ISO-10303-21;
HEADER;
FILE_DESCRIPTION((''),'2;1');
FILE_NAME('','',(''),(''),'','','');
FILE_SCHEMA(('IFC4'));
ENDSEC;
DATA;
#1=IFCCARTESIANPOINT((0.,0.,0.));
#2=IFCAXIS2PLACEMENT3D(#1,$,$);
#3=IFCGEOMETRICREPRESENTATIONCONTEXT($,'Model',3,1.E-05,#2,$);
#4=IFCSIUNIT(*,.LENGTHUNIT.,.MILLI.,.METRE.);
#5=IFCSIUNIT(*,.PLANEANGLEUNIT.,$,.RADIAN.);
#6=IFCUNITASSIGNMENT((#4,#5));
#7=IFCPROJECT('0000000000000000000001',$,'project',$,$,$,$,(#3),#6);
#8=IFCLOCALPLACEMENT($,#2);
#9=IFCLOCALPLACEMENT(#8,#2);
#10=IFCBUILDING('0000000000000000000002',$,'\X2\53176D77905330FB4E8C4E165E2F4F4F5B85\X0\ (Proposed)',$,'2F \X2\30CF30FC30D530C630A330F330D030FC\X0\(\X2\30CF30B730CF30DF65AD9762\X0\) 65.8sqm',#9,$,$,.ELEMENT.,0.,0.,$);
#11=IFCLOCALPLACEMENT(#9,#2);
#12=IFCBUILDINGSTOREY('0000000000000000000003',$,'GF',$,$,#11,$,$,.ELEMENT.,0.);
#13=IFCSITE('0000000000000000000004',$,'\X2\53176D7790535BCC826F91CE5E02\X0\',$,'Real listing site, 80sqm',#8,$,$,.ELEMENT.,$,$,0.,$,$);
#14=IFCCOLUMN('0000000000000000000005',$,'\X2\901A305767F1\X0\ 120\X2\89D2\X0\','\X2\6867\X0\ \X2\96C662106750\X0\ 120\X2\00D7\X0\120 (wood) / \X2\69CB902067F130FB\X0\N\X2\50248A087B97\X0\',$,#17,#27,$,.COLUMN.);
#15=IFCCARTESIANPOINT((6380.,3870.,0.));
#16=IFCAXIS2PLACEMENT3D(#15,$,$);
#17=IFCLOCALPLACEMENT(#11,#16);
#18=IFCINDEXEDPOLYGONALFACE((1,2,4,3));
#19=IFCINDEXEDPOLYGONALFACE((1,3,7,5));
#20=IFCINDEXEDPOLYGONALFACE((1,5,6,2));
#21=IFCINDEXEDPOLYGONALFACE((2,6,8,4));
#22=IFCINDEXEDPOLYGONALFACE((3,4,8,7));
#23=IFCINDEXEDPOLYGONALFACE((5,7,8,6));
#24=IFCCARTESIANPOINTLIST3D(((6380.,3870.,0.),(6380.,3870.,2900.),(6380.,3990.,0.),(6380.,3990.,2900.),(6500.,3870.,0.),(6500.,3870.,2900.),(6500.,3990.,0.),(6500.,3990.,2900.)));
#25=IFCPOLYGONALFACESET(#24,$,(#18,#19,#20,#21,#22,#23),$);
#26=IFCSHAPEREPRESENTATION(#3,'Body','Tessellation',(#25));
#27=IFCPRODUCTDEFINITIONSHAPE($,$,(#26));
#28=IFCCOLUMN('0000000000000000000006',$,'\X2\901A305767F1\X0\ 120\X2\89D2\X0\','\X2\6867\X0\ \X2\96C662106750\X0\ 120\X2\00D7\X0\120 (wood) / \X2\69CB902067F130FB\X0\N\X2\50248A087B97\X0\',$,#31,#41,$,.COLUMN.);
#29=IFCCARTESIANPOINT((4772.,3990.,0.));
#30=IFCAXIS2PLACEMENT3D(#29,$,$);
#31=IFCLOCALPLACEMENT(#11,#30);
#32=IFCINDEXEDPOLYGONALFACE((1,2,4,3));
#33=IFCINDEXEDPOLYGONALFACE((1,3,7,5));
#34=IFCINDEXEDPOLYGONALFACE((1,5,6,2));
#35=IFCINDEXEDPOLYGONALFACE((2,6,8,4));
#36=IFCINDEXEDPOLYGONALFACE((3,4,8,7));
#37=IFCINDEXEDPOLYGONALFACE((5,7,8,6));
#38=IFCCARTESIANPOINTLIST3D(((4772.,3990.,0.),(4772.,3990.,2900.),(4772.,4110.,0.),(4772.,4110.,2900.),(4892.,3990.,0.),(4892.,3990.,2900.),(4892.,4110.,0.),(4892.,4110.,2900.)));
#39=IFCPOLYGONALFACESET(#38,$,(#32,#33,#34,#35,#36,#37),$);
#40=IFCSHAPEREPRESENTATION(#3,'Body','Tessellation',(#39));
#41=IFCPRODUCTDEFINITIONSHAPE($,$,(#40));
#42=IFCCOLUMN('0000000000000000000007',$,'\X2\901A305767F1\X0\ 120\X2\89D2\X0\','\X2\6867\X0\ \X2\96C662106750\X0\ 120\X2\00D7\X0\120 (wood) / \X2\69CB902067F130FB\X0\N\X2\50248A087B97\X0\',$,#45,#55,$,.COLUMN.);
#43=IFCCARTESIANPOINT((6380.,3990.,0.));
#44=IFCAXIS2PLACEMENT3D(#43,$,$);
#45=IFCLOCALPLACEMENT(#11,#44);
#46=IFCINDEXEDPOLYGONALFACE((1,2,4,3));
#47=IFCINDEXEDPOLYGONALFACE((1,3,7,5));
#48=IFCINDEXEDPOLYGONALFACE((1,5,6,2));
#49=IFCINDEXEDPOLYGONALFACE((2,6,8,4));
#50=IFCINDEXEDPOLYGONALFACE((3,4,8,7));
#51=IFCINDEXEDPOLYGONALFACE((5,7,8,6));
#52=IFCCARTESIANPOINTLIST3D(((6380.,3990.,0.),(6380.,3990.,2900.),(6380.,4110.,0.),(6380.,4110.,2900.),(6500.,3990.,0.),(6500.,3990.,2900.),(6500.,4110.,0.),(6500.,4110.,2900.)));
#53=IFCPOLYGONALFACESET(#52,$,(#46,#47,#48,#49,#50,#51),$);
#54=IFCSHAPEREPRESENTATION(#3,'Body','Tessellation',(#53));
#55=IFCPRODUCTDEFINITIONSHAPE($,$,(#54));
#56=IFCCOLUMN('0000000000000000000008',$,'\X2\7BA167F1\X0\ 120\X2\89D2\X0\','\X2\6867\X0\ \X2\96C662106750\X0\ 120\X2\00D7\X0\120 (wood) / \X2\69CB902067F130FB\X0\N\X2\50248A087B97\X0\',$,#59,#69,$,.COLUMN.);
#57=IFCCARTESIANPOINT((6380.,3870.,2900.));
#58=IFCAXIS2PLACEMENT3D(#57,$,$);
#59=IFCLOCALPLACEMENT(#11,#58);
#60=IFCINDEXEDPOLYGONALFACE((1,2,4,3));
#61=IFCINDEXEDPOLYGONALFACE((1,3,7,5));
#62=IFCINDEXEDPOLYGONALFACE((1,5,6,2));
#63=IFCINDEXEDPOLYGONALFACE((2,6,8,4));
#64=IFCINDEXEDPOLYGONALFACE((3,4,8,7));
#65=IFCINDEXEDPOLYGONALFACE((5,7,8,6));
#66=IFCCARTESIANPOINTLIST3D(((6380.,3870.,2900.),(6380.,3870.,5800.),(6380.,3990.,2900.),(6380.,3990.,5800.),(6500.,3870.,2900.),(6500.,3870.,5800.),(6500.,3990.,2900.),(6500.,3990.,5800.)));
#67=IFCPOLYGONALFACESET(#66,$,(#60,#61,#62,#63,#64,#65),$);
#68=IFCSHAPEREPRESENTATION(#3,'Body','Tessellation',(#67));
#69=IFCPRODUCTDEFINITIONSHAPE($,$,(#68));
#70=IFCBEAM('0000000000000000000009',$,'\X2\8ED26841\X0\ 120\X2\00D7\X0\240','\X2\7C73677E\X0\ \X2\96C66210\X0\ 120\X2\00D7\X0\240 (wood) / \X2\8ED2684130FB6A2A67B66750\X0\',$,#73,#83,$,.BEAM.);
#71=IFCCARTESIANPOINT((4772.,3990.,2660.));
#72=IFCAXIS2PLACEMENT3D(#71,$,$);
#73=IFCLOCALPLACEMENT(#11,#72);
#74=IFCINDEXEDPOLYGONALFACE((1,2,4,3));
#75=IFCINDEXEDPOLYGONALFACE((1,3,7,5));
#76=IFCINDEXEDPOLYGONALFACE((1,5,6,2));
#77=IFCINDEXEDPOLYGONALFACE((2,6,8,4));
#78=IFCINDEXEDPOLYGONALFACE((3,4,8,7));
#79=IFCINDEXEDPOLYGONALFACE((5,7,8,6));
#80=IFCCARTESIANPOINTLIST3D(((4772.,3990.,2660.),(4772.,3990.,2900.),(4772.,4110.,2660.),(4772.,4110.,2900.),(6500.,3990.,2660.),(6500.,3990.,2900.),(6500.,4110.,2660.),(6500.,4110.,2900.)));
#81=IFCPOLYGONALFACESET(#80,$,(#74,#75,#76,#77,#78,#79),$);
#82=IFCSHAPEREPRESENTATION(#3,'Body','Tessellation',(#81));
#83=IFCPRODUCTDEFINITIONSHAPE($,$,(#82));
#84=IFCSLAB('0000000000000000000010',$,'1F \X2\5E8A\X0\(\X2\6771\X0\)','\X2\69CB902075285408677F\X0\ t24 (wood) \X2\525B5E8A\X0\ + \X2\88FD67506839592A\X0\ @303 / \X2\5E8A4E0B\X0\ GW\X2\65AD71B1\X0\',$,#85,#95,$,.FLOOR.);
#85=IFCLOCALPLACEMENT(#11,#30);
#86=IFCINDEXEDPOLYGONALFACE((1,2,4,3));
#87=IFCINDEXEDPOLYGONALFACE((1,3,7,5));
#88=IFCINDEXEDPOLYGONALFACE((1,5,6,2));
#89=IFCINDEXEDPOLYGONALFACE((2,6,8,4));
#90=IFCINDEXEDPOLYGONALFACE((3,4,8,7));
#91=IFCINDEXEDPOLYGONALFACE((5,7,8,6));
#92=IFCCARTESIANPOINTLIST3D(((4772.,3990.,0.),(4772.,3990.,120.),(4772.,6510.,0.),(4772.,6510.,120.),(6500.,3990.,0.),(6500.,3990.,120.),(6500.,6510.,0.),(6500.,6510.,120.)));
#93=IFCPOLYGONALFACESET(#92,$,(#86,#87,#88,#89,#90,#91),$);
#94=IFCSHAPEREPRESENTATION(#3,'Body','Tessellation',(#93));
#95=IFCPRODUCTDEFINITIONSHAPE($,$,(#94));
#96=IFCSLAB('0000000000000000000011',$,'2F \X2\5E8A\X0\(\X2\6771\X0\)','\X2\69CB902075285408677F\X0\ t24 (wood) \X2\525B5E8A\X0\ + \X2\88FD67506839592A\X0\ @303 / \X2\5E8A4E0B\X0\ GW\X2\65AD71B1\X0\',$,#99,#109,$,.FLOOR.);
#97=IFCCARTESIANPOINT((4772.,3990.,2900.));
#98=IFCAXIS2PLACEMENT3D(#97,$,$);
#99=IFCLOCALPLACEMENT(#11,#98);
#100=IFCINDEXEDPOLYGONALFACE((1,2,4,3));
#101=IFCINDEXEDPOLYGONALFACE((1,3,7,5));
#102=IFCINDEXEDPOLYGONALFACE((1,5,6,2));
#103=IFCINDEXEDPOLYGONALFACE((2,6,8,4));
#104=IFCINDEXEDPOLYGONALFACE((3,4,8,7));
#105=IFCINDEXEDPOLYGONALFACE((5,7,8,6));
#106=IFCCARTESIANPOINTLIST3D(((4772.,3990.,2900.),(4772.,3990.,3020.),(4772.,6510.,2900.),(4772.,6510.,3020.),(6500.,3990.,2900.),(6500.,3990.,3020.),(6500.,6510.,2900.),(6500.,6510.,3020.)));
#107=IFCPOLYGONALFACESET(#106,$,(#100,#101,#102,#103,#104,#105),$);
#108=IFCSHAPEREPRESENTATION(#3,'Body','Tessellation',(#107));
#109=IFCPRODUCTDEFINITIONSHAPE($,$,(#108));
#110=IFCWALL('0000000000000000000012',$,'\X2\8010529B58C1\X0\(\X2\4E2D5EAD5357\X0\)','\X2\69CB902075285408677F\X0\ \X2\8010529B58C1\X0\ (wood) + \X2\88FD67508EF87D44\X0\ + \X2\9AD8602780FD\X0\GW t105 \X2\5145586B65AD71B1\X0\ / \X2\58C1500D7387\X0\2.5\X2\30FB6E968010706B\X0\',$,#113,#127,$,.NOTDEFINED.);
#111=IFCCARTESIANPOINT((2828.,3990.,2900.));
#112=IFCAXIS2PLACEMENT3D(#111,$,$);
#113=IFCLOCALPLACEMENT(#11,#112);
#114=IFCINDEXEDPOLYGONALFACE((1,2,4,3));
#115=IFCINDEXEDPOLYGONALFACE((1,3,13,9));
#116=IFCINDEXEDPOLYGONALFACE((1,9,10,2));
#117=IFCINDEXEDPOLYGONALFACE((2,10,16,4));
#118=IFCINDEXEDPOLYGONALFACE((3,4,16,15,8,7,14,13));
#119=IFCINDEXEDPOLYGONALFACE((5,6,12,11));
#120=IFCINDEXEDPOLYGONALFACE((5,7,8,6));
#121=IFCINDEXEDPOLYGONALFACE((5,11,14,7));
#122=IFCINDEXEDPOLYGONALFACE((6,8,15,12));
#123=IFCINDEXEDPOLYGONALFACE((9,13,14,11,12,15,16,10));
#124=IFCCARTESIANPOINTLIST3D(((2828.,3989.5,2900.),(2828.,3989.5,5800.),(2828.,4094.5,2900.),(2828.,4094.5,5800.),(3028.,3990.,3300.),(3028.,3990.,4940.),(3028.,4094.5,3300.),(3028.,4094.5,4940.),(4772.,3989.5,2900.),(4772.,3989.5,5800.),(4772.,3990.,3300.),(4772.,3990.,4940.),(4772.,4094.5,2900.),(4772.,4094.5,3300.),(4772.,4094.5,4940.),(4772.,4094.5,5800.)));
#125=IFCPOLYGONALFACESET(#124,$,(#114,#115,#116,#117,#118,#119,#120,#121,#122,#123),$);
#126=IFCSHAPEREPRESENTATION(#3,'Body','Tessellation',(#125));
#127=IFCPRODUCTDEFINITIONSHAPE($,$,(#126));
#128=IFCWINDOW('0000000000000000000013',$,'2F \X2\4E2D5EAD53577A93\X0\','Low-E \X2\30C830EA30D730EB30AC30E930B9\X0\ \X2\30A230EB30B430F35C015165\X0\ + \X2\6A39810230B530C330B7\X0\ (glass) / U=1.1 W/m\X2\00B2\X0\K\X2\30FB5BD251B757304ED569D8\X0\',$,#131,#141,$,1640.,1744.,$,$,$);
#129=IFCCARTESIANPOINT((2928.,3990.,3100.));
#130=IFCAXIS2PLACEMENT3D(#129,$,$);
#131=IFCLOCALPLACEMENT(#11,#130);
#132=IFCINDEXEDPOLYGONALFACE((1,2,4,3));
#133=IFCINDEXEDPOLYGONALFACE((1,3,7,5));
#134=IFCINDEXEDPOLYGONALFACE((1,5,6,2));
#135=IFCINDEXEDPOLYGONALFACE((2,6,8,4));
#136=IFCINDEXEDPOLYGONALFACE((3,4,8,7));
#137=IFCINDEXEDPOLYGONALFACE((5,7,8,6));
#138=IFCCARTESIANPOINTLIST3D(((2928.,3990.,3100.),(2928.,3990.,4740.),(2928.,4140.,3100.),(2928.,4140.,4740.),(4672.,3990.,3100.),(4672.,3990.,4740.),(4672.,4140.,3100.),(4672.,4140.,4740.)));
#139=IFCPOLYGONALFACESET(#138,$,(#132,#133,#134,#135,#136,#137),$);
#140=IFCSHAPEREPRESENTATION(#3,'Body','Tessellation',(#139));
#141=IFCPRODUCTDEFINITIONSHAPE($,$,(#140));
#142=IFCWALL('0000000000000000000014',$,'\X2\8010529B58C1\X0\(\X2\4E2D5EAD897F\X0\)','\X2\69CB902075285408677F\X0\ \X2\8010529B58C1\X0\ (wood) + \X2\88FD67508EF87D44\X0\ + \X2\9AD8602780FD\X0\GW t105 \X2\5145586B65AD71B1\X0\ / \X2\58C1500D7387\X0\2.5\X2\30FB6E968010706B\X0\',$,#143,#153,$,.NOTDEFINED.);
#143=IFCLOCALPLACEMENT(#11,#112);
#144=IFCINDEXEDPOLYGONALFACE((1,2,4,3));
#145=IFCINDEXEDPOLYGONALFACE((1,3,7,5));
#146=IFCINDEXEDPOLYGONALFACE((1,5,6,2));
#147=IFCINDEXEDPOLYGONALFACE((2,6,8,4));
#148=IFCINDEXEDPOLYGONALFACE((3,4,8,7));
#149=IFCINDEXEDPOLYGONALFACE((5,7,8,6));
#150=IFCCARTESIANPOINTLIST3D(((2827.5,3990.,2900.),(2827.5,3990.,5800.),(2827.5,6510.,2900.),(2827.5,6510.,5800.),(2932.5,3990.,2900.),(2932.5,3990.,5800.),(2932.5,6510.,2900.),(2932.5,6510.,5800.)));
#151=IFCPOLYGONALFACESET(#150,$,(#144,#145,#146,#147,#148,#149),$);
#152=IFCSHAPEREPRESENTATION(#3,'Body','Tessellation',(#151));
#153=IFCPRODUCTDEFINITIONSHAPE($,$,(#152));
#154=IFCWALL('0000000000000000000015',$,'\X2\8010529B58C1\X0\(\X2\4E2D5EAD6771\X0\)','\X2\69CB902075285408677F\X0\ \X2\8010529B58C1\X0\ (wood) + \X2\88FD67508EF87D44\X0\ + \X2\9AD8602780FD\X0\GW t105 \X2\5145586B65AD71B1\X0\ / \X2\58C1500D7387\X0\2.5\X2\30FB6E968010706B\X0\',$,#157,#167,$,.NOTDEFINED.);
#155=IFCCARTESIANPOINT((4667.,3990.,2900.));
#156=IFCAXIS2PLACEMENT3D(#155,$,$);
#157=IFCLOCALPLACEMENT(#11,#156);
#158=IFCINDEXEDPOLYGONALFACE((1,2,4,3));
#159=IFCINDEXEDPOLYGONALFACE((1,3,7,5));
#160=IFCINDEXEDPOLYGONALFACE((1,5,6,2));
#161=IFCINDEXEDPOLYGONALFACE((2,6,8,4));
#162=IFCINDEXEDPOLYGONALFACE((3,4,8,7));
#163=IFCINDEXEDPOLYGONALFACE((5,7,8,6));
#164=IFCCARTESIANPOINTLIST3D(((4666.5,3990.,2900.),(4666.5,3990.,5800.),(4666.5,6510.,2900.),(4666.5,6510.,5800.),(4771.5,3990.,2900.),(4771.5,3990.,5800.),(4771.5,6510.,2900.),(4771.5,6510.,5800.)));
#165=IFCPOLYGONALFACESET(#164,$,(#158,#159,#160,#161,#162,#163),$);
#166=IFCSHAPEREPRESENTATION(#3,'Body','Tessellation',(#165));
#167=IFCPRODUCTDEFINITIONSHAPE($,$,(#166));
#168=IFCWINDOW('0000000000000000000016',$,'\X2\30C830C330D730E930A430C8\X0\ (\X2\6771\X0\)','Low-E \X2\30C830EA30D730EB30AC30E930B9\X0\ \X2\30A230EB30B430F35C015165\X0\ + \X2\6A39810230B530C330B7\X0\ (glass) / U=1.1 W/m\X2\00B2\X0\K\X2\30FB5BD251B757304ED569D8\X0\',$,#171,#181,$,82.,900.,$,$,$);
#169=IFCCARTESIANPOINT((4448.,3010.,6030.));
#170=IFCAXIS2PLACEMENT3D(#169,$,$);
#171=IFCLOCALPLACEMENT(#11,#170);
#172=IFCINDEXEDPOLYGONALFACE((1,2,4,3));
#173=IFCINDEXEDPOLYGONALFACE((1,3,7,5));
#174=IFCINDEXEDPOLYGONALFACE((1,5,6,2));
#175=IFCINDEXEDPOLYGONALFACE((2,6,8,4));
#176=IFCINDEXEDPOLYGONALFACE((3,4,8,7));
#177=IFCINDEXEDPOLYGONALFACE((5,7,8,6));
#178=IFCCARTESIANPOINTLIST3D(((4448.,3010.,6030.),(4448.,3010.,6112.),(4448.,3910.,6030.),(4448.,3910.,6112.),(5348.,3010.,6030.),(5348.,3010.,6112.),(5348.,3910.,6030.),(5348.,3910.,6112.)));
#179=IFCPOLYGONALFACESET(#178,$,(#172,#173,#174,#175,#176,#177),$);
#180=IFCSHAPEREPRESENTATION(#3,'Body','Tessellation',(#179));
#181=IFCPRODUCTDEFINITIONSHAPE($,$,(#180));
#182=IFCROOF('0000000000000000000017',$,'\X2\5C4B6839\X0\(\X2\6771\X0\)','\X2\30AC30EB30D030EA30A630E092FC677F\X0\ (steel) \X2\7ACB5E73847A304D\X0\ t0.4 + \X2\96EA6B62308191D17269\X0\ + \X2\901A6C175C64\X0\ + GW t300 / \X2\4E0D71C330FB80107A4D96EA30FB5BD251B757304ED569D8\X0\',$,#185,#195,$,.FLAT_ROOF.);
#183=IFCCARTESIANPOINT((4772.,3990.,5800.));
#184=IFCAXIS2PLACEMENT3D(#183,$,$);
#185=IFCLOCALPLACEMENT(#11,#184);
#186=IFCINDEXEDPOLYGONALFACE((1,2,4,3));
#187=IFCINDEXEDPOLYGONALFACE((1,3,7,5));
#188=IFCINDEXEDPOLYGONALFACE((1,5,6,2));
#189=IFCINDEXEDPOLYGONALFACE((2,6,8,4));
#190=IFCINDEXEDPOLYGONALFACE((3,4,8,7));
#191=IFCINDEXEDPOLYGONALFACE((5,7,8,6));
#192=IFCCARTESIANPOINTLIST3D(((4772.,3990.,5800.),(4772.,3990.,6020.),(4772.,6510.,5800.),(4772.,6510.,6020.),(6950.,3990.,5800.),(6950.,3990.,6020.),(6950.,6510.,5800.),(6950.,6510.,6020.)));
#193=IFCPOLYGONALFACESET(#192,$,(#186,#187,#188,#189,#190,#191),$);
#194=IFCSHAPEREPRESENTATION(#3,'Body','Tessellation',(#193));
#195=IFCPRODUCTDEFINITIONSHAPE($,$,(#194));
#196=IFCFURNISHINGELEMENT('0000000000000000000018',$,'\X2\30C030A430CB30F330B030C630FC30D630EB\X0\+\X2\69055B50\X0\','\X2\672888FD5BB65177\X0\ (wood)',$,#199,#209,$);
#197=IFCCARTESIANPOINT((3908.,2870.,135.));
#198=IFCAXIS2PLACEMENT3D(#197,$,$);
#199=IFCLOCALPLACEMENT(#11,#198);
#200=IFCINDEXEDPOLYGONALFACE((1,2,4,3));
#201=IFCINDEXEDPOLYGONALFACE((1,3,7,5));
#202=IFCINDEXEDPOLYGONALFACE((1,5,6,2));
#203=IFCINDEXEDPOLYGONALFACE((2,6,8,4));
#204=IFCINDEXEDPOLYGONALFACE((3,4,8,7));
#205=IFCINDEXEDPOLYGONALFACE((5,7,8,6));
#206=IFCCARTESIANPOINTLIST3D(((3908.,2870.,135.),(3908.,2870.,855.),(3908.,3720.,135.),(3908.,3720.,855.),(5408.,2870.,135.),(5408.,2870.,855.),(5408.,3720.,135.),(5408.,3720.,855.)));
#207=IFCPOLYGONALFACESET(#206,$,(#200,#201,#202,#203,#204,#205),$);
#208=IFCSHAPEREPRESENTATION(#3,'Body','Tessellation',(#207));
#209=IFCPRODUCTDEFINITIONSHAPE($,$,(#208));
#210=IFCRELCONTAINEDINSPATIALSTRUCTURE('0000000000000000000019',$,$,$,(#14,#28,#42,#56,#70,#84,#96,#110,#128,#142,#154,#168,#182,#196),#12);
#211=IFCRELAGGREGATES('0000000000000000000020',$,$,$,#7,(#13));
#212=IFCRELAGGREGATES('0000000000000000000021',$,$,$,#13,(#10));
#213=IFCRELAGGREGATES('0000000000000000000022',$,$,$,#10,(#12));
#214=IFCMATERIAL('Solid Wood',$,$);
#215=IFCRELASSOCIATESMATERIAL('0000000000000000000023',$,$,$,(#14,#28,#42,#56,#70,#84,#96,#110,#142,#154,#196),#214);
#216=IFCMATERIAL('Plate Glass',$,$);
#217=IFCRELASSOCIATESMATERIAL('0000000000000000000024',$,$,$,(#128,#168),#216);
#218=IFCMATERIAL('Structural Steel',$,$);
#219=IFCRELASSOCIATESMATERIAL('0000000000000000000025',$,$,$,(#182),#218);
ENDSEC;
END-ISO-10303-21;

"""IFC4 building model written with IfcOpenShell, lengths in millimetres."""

from ifc_helpers import new_model, si_unit, frame, frame_2d, origin, place, context, project, spatial, rectangle, extrude, material, element, fill, save


model = new_model("IFC4")

# Units and contexts
model_context = context("Model", 3, precision=1e-05, world=origin())
ifc_project = project(units=[si_unit("LENGTHUNIT", "METRE", prefix="MILLI"), si_unit("PLANEANGLEUNIT", "RADIAN")], contexts=[model_context])

# Site, building, storey
site_placement = place(None, origin())
site = spatial("IfcSite", under=ifc_project, at=site_placement, Name="北海道富良野市", ObjectType="Real listing site, 80sqm", CompositionType="ELEMENT", RefElevation=0.0)
building_placement = place(site_placement, origin())
building = spatial("IfcBuilding", under=site, at=building_placement, Name="北海道・二世帯住宅 (Proposed)", ObjectType="2F ハーフティンバー(ハシハミ断面) 65.8sqm", CompositionType="ELEMENT", ElevationOfRefHeight=0.0, ElevationOfTerrain=0.0)
storey_placement = place(building_placement, origin())
storey = spatial("IfcBuildingStorey", under=building, at=storey_placement, Name="GF", CompositionType="ELEMENT", Elevation=0.0)

# Columns
ifc_material_1 = material(Name="Solid Wood")
column_1_placement = place(storey_placement, frame((6380.0, 3870.0, 0.0)))
element("IfcColumn", 1, at=column_1_placement, inside=storey, material=ifc_material_1, Name="通し柱 120角", Description="桧 集成材 120×120 (wood) / 構造柱・N値計算", PredefinedType="COLUMN", context=model_context, shape_type="SweptSolid", body=[
    extrude(rectangle(XDim=120.0, YDim=120.0, at=frame_2d((60.0, 60.0))), frame((6380.0, 3870.0, 0.0)), (0.0, 0.0, 1.0), 2900.0),
])
column_2_placement = place(storey_placement, frame((4772.0, 3990.0, 0.0)))
element("IfcColumn", 2, at=column_2_placement, inside=storey, material=ifc_material_1, Name="通し柱 120角", Description="桧 集成材 120×120 (wood) / 構造柱・N値計算", PredefinedType="COLUMN", context=model_context, shape_type="SweptSolid", body=[
    extrude(rectangle(XDim=120.0, YDim=120.0, at=frame_2d((60.0, 60.0))), frame((4772.0, 3990.0, 0.0)), (0.0, 0.0, 1.0), 2900.0),
])
column_3_placement = place(storey_placement, frame((6380.0, 3990.0, 0.0)))
element("IfcColumn", 3, at=column_3_placement, inside=storey, material=ifc_material_1, Name="通し柱 120角", Description="桧 集成材 120×120 (wood) / 構造柱・N値計算", PredefinedType="COLUMN", context=model_context, shape_type="SweptSolid", body=[
    extrude(rectangle(XDim=120.0, YDim=120.0, at=frame_2d((60.0, 60.0))), frame((6380.0, 3990.0, 0.0)), (0.0, 0.0, 1.0), 2900.0),
])
column_4_placement = place(storey_placement, frame((6380.0, 3870.0, 2900.0)))
element("IfcColumn", 4, at=column_4_placement, inside=storey, material=ifc_material_1, Name="管柱 120角", Description="桧 集成材 120×120 (wood) / 構造柱・N値計算", PredefinedType="COLUMN", context=model_context, shape_type="SweptSolid", body=[
    extrude(rectangle(XDim=120.0, YDim=120.0, at=frame_2d((60.0, 60.0))), frame((6380.0, 3870.0, 2900.0)), (0.0, 0.0, 1.0), 2900.0),
])

# Beam
beam_1_placement = place(storey_placement, frame((4772.0, 3990.0, 2660.0)))
element("IfcBeam", 5, at=beam_1_placement, inside=storey, material=ifc_material_1, Name="軒桁 120×240", Description="米松 集成 120×240 (wood) / 軒桁・横架材", PredefinedType="BEAM", context=model_context, shape_type="SweptSolid", body=[
    extrude(rectangle(XDim=1728.0, YDim=120.0, at=frame_2d((864.0, 60.0))), frame((4772.0, 3990.0, 2660.0)), (0.0, 0.0, 1.0), 240.0),
])

# Slabs
slab_1_placement = place(storey_placement, frame((4772.0, 3990.0, 0.0)))
element("IfcSlab", 6, at=slab_1_placement, inside=storey, material=ifc_material_1, Name="1F 床(東)", Description="構造用合板 t24 (wood) 剛床 + 製材根太 @303 / 床下 GW断熱", PredefinedType="FLOOR", context=model_context, shape_type="SweptSolid", body=[
    extrude(rectangle(XDim=1728.0, YDim=2520.0, at=frame_2d((864.0, 1260.0))), frame((4772.0, 3990.0, 0.0)), (0.0, 0.0, 1.0), 120.0),
])
slab_2_placement = place(storey_placement, frame((4772.0, 3990.0, 2900.0)))
element("IfcSlab", 7, at=slab_2_placement, inside=storey, material=ifc_material_1, Name="2F 床(東)", Description="構造用合板 t24 (wood) 剛床 + 製材根太 @303 / 床下 GW断熱", PredefinedType="FLOOR", context=model_context, shape_type="SweptSolid", body=[
    extrude(rectangle(XDim=1728.0, YDim=2520.0, at=frame_2d((864.0, 1260.0))), frame((4772.0, 3990.0, 2900.0)), (0.0, 0.0, 1.0), 120.0),
])

# Wall, opening, window
wall_1_placement = place(storey_placement, frame((2828.0, 3990.0, 2900.0)))
wall_1 = element("IfcWall", 8, at=wall_1_placement, inside=storey, material=ifc_material_1, Name="耐力壁(中庭南)", Description="構造用合板 耐力壁 (wood) + 製材軸組 + 高性能GW t105 充填断熱 / 壁倍率2.5・準耐火", PredefinedType="NOTDEFINED", context=model_context, shape_type="SweptSolid", body=[
    extrude(rectangle(XDim=1944.0, YDim=105.0, at=frame_2d((972.0, 52.0))), frame((2828.0, 3990.0, 2900.0)), (0.0, 0.0, 1.0), 2900.0),
])
opening_placement = place(storey_placement, frame((2928.0, 3990.0, 3100.0)))
opening = element("IfcOpeningElement", 9, at=opening_placement, cuts=wall_1, PredefinedType="NOTDEFINED", context=model_context, shape_type="SweptSolid", body=[
    extrude(rectangle(XDim=1744.0, YDim=150.0, at=frame_2d((872.0, 75.0))), frame((2928.0, 3990.0, 3100.0)), (0.0, 0.0, 1.0), 1640.0),
])
ifc_material_2 = material(Name="Plate Glass")
window_1_placement = place(storey_placement, frame((2928.0, 3990.0, 3100.0)))
window_1 = element("IfcWindow", 10, at=window_1_placement, inside=storey, material=ifc_material_2, Name="2F 中庭南窓", Description="Low-E トリプルガラス アルゴン封入 + 樹脂サッシ (glass) / U=1.1 W/m²K・寒冷地仕様", OverallHeight=1640.0, OverallWidth=1744.0, context=model_context, shape_type="SweptSolid", body=[
    extrude(rectangle(XDim=1744.0, YDim=150.0, at=frame_2d((872.0, 75.0))), frame((2928.0, 3990.0, 3100.0)), (0.0, 0.0, 1.0), 1640.0),
])
fill(opening, window_1)

# Walls
wall_2_placement = place(storey_placement, frame((2828.0, 3990.0, 2900.0)))
element("IfcWall", 11, at=wall_2_placement, inside=storey, material=ifc_material_1, Name="耐力壁(中庭西)", Description="構造用合板 耐力壁 (wood) + 製材軸組 + 高性能GW t105 充填断熱 / 壁倍率2.5・準耐火", PredefinedType="NOTDEFINED", context=model_context, shape_type="SweptSolid", body=[
    extrude(rectangle(XDim=105.0, YDim=2520.0, at=frame_2d((52.0, 1260.0))), frame((2828.0, 3990.0, 2900.0)), (0.0, 0.0, 1.0), 2900.0),
])
wall_3_placement = place(storey_placement, frame((4667.0, 3990.0, 2900.0)))
element("IfcWall", 12, at=wall_3_placement, inside=storey, material=ifc_material_1, Name="耐力壁(中庭東)", Description="構造用合板 耐力壁 (wood) + 製材軸組 + 高性能GW t105 充填断熱 / 壁倍率2.5・準耐火", PredefinedType="NOTDEFINED", context=model_context, shape_type="SweptSolid", body=[
    extrude(rectangle(XDim=105.0, YDim=2520.0, at=frame_2d((52.0, 1260.0))), frame((4667.0, 3990.0, 2900.0)), (0.0, 0.0, 1.0), 2900.0),
])

# Window
window_2_placement = place(storey_placement, frame((4448.0, 3010.0, 6030.0)))
element("IfcWindow", 13, at=window_2_placement, inside=storey, material=ifc_material_2, Name="トップライト (東)", Description="Low-E トリプルガラス アルゴン封入 + 樹脂サッシ (glass) / U=1.1 W/m²K・寒冷地仕様", OverallHeight=82.0, OverallWidth=900.0, context=model_context, shape_type="SweptSolid", body=[
    extrude(rectangle(XDim=900.0, YDim=900.0, at=frame_2d((450.0, 450.0))), frame((4448.0, 3010.0, 6030.0)), (0.0, 0.0, 1.0), 82.0),
])

# Roof
ifc_material_3 = material(Name="Structural Steel")
for number, where, name in (
    (14, (4772.0, 3990.0, 5800.0), "屋根(東)"),
):
    element("IfcRoof", number, at=place(storey_placement, frame(where)), inside=storey, material=ifc_material_3, Name=name, Description="ガルバリウム鋼板 (steel) 立平葺き t0.4 + 雪止め金物 + 通気層 + GW t300 / 不燃・耐積雪・寒冷地仕様", PredefinedType="FLAT_ROOF", context=model_context, shape_type="SweptSolid", body=[
        extrude(rectangle(XDim=2178.0, YDim=2520.0, at=frame_2d((1089.0, 1260.0))), frame((4772.0, 3990.0, 5800.0)), (0.0, 0.0, 1.0), 220.0),
    ])

# Furnishing element
furnishing_1_placement = place(storey_placement, frame((3908.0, 2870.0, 135.0)))
element("IfcFurnishingElement", 15, at=furnishing_1_placement, inside=storey, material=ifc_material_1, Name="ダイニングテーブル+椅子", Description="木製家具 (wood)", context=model_context, shape_type="SweptSolid", body=[
    extrude(rectangle(XDim=1500.0, YDim=850.0, at=frame_2d((750.0, 425.0))), frame((3908.0, 2870.0, 135.0)), (0.0, 0.0, 1.0), 720.0),
])

save(model, "model.ifc")
